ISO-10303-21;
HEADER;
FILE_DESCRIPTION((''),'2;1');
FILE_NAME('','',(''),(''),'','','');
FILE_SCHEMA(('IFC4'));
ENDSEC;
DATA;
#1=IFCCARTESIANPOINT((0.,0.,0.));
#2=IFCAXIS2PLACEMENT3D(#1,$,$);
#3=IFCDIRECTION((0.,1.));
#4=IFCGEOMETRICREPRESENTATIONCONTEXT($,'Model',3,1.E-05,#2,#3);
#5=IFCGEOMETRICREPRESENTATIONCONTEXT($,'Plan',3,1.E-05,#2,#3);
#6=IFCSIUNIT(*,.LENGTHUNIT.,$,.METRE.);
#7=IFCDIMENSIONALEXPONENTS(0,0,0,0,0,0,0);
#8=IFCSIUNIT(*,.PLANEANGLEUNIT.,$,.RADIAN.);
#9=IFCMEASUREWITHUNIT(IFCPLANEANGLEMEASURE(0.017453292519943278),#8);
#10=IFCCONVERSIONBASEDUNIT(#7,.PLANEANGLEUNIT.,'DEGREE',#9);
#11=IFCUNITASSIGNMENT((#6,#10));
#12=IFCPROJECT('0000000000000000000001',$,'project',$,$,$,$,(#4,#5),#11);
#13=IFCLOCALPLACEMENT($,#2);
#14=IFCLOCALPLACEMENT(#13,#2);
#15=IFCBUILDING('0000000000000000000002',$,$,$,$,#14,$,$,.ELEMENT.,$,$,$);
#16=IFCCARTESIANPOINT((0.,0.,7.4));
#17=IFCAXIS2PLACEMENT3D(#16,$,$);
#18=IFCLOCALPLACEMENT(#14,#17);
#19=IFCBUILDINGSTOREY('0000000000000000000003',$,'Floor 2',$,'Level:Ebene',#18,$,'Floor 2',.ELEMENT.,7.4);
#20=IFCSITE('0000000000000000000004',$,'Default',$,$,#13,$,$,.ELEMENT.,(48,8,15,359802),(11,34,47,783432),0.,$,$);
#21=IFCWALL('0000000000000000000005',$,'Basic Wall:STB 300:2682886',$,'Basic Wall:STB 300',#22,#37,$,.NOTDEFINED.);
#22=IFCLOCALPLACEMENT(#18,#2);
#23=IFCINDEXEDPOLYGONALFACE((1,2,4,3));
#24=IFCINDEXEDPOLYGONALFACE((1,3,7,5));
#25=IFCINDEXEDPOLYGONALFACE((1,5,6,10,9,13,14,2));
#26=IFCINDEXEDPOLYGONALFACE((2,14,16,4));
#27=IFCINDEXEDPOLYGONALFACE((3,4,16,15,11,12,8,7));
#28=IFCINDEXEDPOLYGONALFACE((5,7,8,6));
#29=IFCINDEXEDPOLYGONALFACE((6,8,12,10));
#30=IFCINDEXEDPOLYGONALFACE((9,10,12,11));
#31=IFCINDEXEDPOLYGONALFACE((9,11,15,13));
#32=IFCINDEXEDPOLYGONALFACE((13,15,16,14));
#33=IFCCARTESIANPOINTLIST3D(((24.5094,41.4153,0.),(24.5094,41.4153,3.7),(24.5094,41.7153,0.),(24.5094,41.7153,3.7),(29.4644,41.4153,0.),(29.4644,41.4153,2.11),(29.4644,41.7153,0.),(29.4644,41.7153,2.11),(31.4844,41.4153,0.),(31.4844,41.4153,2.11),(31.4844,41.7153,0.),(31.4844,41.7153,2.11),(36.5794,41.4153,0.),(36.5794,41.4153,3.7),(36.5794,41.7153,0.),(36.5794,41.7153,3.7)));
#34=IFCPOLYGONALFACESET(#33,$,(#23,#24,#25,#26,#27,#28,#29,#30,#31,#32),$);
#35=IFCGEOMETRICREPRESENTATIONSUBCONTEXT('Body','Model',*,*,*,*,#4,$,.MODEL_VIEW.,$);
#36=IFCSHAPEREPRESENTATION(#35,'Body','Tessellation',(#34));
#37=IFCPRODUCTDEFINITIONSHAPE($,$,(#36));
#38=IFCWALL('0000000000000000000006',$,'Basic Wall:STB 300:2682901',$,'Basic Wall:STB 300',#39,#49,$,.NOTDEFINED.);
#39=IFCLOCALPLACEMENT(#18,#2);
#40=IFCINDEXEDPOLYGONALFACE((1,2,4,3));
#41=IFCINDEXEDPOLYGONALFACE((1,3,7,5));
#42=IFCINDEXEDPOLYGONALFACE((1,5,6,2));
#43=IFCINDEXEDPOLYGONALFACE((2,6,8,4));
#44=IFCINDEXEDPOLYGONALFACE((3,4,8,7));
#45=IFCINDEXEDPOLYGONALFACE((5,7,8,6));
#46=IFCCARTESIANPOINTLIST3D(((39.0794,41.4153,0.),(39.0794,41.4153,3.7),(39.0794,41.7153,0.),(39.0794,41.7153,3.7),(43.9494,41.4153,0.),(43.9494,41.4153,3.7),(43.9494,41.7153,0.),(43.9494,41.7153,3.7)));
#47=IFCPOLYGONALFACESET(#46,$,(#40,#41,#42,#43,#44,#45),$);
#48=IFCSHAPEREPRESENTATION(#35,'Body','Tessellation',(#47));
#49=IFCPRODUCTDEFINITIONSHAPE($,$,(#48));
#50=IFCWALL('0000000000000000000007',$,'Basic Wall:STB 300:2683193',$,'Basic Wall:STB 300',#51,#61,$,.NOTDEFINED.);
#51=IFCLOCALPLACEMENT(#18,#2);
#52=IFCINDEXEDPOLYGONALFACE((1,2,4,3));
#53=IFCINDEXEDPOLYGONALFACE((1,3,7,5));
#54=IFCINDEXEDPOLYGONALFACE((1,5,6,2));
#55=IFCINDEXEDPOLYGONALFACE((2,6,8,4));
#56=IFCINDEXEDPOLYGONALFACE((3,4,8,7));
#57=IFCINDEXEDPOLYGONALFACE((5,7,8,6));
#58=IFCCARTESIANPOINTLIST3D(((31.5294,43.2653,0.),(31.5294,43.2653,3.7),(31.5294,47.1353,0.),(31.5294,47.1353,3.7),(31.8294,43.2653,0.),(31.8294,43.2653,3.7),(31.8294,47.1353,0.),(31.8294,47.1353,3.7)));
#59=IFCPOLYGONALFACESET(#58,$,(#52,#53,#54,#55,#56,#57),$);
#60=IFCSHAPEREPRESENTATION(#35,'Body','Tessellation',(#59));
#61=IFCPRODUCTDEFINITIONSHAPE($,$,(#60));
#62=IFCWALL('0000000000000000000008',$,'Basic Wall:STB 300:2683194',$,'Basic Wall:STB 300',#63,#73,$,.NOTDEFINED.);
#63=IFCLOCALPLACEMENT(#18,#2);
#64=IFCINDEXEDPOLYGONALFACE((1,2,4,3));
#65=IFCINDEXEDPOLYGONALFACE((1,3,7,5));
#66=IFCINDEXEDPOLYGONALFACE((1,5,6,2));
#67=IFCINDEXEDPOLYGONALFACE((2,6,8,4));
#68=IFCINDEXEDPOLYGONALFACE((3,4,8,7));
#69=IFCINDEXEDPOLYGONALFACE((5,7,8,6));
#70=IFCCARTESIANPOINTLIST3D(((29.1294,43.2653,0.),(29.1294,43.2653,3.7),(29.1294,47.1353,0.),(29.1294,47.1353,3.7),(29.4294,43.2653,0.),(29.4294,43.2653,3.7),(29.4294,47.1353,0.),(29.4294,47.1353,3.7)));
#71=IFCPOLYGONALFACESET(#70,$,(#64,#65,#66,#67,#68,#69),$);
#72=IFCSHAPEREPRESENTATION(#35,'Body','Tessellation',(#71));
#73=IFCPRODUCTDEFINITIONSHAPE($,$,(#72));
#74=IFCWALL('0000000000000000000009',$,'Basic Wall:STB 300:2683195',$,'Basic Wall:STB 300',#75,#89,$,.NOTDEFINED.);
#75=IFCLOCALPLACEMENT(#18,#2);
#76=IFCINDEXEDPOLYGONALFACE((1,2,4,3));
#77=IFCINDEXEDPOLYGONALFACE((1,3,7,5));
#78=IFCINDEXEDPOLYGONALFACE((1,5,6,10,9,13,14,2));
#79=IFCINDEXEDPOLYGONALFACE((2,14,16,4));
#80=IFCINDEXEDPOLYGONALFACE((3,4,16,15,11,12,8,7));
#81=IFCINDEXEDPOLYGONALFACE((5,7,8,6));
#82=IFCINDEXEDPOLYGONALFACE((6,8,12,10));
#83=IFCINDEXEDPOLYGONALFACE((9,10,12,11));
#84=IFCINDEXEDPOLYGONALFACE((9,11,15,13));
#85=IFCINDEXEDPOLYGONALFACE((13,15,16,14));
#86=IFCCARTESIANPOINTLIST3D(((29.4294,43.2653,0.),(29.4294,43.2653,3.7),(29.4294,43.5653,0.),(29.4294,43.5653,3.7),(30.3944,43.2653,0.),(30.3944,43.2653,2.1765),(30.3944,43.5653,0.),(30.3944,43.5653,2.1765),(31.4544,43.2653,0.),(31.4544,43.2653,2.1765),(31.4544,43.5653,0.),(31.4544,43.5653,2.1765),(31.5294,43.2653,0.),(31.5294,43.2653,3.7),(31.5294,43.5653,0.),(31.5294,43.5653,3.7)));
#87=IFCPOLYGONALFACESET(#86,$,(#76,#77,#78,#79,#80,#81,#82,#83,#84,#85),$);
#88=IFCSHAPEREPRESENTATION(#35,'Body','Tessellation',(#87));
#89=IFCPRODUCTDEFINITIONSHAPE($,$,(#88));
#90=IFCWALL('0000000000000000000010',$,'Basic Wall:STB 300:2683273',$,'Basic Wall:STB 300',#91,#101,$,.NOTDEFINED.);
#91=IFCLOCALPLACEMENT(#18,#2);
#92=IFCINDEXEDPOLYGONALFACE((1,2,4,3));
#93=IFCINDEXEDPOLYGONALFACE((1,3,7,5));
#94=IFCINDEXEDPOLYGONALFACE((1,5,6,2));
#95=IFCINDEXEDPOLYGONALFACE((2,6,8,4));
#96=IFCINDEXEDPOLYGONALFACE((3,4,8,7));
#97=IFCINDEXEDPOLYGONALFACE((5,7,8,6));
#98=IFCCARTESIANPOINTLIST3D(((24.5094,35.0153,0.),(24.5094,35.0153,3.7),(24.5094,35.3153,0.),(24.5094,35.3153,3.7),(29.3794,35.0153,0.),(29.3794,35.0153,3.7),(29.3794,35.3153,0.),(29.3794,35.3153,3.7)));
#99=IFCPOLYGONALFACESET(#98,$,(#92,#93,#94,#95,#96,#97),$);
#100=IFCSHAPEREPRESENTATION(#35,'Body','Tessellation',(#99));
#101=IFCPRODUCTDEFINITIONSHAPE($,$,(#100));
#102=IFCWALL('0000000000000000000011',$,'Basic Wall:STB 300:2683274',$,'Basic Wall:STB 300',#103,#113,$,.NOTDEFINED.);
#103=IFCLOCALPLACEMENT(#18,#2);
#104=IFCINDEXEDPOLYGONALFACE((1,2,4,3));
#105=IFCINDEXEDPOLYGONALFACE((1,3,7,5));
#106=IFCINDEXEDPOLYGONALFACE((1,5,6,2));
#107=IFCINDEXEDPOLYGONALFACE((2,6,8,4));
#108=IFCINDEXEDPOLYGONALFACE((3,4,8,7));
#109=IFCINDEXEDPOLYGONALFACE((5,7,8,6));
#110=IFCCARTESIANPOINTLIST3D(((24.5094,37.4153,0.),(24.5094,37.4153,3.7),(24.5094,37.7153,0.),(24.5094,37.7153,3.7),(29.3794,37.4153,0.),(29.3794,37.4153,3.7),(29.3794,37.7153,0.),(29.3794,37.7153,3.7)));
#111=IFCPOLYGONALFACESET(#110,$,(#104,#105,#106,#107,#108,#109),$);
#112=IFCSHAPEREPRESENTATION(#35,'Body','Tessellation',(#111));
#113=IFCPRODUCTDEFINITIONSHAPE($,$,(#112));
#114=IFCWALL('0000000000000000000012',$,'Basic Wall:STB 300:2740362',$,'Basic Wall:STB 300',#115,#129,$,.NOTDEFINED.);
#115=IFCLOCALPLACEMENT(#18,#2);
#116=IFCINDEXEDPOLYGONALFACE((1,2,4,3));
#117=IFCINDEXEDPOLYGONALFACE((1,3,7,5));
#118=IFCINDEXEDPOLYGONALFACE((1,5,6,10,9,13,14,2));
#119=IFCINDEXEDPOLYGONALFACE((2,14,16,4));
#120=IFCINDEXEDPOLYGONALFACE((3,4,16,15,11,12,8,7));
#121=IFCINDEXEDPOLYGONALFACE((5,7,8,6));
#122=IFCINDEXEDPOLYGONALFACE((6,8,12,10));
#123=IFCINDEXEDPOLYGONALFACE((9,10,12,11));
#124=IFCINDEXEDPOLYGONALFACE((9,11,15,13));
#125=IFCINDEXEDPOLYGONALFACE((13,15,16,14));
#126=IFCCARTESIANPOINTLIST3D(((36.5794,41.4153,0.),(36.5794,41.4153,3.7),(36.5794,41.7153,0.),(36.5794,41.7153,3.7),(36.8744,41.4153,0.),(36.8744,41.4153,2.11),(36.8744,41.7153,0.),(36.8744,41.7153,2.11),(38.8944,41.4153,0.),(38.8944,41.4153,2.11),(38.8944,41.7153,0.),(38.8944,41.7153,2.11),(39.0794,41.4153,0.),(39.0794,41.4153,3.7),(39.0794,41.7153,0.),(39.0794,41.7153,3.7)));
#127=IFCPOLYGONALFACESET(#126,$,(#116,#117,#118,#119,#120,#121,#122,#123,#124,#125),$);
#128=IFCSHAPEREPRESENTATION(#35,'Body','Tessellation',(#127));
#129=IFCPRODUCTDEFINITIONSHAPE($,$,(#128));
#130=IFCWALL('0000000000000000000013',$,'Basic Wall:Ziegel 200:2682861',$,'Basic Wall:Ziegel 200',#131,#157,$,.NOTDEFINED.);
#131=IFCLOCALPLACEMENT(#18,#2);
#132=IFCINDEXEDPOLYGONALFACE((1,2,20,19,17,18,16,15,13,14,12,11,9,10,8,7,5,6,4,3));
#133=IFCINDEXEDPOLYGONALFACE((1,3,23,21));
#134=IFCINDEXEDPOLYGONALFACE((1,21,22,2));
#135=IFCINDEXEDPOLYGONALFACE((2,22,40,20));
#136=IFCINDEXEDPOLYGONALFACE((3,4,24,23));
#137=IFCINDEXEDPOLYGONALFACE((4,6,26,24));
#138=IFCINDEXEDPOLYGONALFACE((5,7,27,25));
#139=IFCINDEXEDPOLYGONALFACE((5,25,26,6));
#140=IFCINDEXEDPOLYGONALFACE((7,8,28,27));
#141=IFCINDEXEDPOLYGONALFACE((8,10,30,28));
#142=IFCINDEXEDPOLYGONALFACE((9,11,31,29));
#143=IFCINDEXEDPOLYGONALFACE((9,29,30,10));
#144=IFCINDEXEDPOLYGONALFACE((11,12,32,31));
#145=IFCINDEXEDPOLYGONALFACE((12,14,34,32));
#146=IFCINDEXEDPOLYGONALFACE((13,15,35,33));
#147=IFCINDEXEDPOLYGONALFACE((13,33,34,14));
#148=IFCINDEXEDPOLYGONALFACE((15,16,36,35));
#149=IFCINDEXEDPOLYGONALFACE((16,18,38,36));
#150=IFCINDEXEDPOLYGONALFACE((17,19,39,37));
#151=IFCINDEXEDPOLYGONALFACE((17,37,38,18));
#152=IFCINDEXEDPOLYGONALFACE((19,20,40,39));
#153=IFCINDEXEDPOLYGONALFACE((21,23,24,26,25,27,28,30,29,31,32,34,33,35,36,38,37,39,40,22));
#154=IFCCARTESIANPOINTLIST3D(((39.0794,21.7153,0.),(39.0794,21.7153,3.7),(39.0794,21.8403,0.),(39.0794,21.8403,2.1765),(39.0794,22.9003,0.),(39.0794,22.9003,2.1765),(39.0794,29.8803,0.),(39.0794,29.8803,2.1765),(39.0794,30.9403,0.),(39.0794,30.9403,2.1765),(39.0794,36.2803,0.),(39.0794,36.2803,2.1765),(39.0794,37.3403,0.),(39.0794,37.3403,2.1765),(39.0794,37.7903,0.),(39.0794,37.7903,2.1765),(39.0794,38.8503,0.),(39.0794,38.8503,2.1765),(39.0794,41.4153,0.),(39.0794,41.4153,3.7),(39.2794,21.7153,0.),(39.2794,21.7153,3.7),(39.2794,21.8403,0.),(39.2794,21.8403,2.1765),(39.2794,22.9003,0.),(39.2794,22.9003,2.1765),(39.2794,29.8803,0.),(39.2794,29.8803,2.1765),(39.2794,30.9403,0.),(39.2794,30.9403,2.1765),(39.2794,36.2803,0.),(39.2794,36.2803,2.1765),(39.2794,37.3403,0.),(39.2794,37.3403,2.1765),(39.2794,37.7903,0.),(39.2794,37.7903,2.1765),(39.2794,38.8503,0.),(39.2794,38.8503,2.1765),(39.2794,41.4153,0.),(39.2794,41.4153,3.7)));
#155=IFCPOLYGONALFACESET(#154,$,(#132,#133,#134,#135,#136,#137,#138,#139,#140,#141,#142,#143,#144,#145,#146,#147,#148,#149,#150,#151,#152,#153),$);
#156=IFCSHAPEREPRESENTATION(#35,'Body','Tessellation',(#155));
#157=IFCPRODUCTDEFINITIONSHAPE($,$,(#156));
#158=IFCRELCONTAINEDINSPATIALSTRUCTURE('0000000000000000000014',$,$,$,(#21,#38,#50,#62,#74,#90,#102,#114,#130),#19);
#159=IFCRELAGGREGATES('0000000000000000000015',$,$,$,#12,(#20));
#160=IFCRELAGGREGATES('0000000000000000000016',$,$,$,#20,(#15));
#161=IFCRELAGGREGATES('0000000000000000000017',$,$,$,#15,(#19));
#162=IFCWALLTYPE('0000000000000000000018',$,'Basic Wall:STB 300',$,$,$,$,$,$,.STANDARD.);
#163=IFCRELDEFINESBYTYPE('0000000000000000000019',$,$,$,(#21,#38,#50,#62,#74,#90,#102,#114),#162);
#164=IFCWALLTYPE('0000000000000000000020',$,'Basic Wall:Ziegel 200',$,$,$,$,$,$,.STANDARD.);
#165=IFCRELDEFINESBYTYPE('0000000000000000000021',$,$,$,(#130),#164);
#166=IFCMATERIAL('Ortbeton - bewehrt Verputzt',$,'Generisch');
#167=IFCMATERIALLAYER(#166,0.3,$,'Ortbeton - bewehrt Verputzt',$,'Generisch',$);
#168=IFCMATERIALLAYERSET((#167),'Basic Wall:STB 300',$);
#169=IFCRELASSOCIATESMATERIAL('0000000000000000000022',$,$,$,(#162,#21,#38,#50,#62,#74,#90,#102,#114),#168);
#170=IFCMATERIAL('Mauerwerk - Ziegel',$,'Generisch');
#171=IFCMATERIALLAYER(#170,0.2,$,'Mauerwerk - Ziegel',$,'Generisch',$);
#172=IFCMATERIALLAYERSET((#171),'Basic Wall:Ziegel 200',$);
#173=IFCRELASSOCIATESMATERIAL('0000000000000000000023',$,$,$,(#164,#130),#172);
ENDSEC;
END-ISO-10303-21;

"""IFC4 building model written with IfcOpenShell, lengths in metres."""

from ifc_helpers import new_model, entity, si_unit, converted_unit, direction, frame, frame_2d, origin, place, context, subcontext, project, spatial, rectangle, extrude, material, layer, layer_set, layer_usage, type_object, element, save


model = new_model("IFC4")

# Units and contexts
model_context = context("Model", 3, precision=1e-05, world=origin(), true_north=direction((0.0, 1.0)))
plan_context = context("Plan", 3, precision=1e-05, world=origin(), true_north=direction((0.0, 1.0)))
body_context = subcontext(model_context, "Body", "Model", "MODEL_VIEW")
ifc_project = project(units=[si_unit("LENGTHUNIT", "METRE"), converted_unit("PLANEANGLEUNIT", "DEGREE", entity("IfcPlaneAngleMeasure", 0.017453292519943278), si_unit("PLANEANGLEUNIT", "RADIAN"), dimensions=[0, 0, 0, 0, 0, 0, 0])], contexts=[model_context, plan_context])

# Site, building, storey
site_placement = place(None, origin())
site = spatial("IfcSite", under=ifc_project, at=site_placement, Name="Default", CompositionType="ELEMENT", RefLatitude=(48, 8, 15, 359802), RefLongitude=(11, 34, 47, 783432), RefElevation=0.0)
building_placement = place(site_placement, origin())
building = spatial("IfcBuilding", under=site, at=building_placement, CompositionType="ELEMENT")
storey_placement = place(building_placement, frame((0.0, 0.0, 7.4)))
storey = spatial("IfcBuildingStorey", under=building, at=storey_placement, Name="Floor 2", ObjectType="Level:Ebene", LongName="Floor 2", CompositionType="ELEMENT", Elevation=7.4)

# Wall, opening
ifc_material_1 = material(Name="Ortbeton - bewehrt Verputzt", Category="Generisch")
ifc_layer_1 = layer(ifc_material_1, 0.3, Name="Ortbeton - bewehrt Verputzt", Category="Generisch")
ifc_layer_set_1 = layer_set([ifc_layer_1], Name="Basic Wall:STB 300")
ifc_layer_usage_1 = layer_usage(ifc_layer_set_1, "AXIS2", "NEGATIVE", 0.15)
wall_type_1 = type_object("IfcWallType", Name="Basic Wall:STB 300", PredefinedType="STANDARD", material=ifc_layer_set_1)
wall_1_placement = place(storey_placement, frame((24.5094, 41.5653, 0.0)))
wall_1 = element("IfcWall", 1, at=wall_1_placement, inside=storey, type_object=wall_type_1, material=ifc_layer_usage_1, Name="Basic Wall:STB 300:2682886", ObjectType="Basic Wall:STB 300", PredefinedType="NOTDEFINED", context=body_context, shape_type="SweptSolid", body=[
    extrude(rectangle(XDim=12.07, YDim=0.3, at=frame_2d((6.035, 0.0), x_axis=(-1.0, 0.0))), origin(), (0.0, 0.0, 1.0), 3.7),
])
opening_1_placement = place(wall_1_placement, frame((6.975, 0.15, 0.0)))
element("IfcOpeningElement", 2, at=opening_1_placement, cuts=wall_1, PredefinedType="OPENING", context=body_context, shape_type="SweptSolid", body=[
    extrude(rectangle(XDim=2.11, YDim=2.02, at=frame_2d((1.055, 1.01), x_axis=(1.0, 0.0))), frame((0.0, 0.0, 0.0), z_axis=(0.0, -1.0, 0.0), x_axis=(0.0, 0.0, 1.0)), (0.0, 0.0, 1.0), 0.3),
])

# Walls
wall_2_placement = place(storey_placement, frame((39.0794, 41.5653, 0.0)))
element("IfcWall", 3, at=wall_2_placement, inside=storey, type_object=wall_type_1, material=ifc_layer_usage_1, Name="Basic Wall:STB 300:2682901", ObjectType="Basic Wall:STB 300", PredefinedType="NOTDEFINED", context=body_context, shape_type="SweptSolid", body=[
    extrude(rectangle(XDim=4.87, YDim=0.3, at=frame_2d((2.435, 0.0), x_axis=(-1.0, 0.0))), origin(), (0.0, 0.0, 1.0), 3.7),
])
wall_3_placement = place(storey_placement, frame((31.6794, 47.1353, 0.0), z_axis=(0.0, 0.0, 1.0), x_axis=(0.0, -1.0, 0.0)))
element("IfcWall", 4, at=wall_3_placement, inside=storey, type_object=wall_type_1, material=ifc_layer_usage_1, Name="Basic Wall:STB 300:2683193", ObjectType="Basic Wall:STB 300", PredefinedType="NOTDEFINED", context=body_context, shape_type="SweptSolid", body=[
    extrude(rectangle(XDim=3.87, YDim=0.3, at=frame_2d((1.935, 0.0), x_axis=(-1.0, 0.0))), origin(), (0.0, 0.0, 1.0), 3.7),
])
wall_4_placement = place(storey_placement, frame((29.2794, 43.2653, 0.0), z_axis=(0.0, 0.0, 1.0), x_axis=(0.0, 1.0, 0.0)))
element("IfcWall", 5, at=wall_4_placement, inside=storey, type_object=wall_type_1, material=ifc_layer_usage_1, Name="Basic Wall:STB 300:2683194", ObjectType="Basic Wall:STB 300", PredefinedType="NOTDEFINED", context=body_context, shape_type="SweptSolid", body=[
    extrude(rectangle(XDim=3.87, YDim=0.3, at=frame_2d((1.935, 0.0), x_axis=(-1.0, 0.0))), origin(), (0.0, 0.0, 1.0), 3.7),
])

# Wall, opening
wall_5_placement = place(storey_placement, frame((29.4294, 43.4153, 0.0)))
wall_5 = element("IfcWall", 6, at=wall_5_placement, inside=storey, type_object=wall_type_1, material=ifc_layer_usage_1, Name="Basic Wall:STB 300:2683195", ObjectType="Basic Wall:STB 300", PredefinedType="NOTDEFINED", context=body_context, shape_type="SweptSolid", body=[
    extrude(rectangle(XDim=2.1, YDim=0.3, at=frame_2d((1.05, 0.0), x_axis=(1.0, 0.0))), origin(), (0.0, 0.0, 1.0), 3.7),
])
opening_2_placement = place(wall_5_placement, frame((0.965, -0.15, 0.0)))
element("IfcOpeningElement", 7, at=opening_2_placement, cuts=wall_5, PredefinedType="OPENING", context=body_context, shape_type="SweptSolid", body=[
    extrude(rectangle(XDim=2.1765, YDim=1.06, at=frame_2d((1.0882, 0.53), x_axis=(1.0, 0.0))), frame((0.0, 0.0, 0.0), z_axis=(0.0, 1.0, 0.0), x_axis=(0.0, 0.0, 1.0)), (0.0, 0.0, 1.0), 0.3),
])

# Walls
wall_6_placement = place(storey_placement, frame((29.3794, 35.1653, 0.0), z_axis=(0.0, 0.0, 1.0), x_axis=(-1.0, 0.0, 0.0)))
element("IfcWall", 8, at=wall_6_placement, inside=storey, type_object=wall_type_1, material=ifc_layer_usage_1, Name="Basic Wall:STB 300:2683273", ObjectType="Basic Wall:STB 300", PredefinedType="NOTDEFINED", context=body_context, shape_type="SweptSolid", body=[
    extrude(rectangle(XDim=4.87, YDim=0.3, at=frame_2d((2.435, 0.0), x_axis=(-1.0, 0.0))), origin(), (0.0, 0.0, 1.0), 3.7),
])
wall_7_placement = place(storey_placement, frame((29.3794, 37.5653, 0.0), z_axis=(0.0, 0.0, 1.0), x_axis=(-1.0, 0.0, 0.0)))
element("IfcWall", 9, at=wall_7_placement, inside=storey, type_object=wall_type_1, material=ifc_layer_usage_1, Name="Basic Wall:STB 300:2683274", ObjectType="Basic Wall:STB 300", PredefinedType="NOTDEFINED", context=body_context, shape_type="SweptSolid", body=[
    extrude(rectangle(XDim=4.87, YDim=0.3, at=frame_2d((2.435, 0.0), x_axis=(-1.0, 0.0))), origin(), (0.0, 0.0, 1.0), 3.7),
])

# Wall, opening
wall_8_placement = place(storey_placement, frame((36.5794, 41.5653, 0.0)))
wall_8 = element("IfcWall", 10, at=wall_8_placement, inside=storey, type_object=wall_type_1, material=ifc_layer_usage_1, Name="Basic Wall:STB 300:2740362", ObjectType="Basic Wall:STB 300", PredefinedType="NOTDEFINED", context=body_context, shape_type="SweptSolid", body=[
    extrude(rectangle(XDim=2.5, YDim=0.3, at=frame_2d((1.25, 0.0), x_axis=(-1.0, 0.0))), origin(), (0.0, 0.0, 1.0), 3.7),
])
opening_3_placement = place(wall_8_placement, frame((2.315, 0.15, 0.0)))
element("IfcOpeningElement", 11, at=opening_3_placement, cuts=wall_8, PredefinedType="OPENING", context=body_context, shape_type="SweptSolid", body=[
    extrude(rectangle(XDim=2.11, YDim=2.02, at=frame_2d((1.055, 1.01), x_axis=(1.0, 0.0))), frame((0.0, 0.0, 0.0), z_axis=(0.0, -1.0, 0.0), x_axis=(0.0, 0.0, 1.0)), (0.0, 0.0, 1.0), 0.3),
])

# Wall, openings
ifc_material_2 = material(Name="Mauerwerk - Ziegel", Category="Generisch")
ifc_layer_2 = layer(ifc_material_2, 0.2, Name="Mauerwerk - Ziegel", Category="Generisch")
ifc_layer_set_2 = layer_set([ifc_layer_2], Name="Basic Wall:Ziegel 200")
ifc_layer_usage_2 = layer_usage(ifc_layer_set_2, "AXIS2", "NEGATIVE", 0.1)
wall_type_2 = type_object("IfcWallType", Name="Basic Wall:Ziegel 200", PredefinedType="STANDARD", material=ifc_layer_set_2)
wall_9_placement = place(storey_placement, frame((39.1794, 41.4153, 0.0), z_axis=(0.0, 0.0, 1.0), x_axis=(0.0, -1.0, 0.0)))
wall_9 = element("IfcWall", 12, at=wall_9_placement, inside=storey, type_object=wall_type_2, material=ifc_layer_usage_2, Name="Basic Wall:Ziegel 200:2682861", ObjectType="Basic Wall:Ziegel 200", PredefinedType="NOTDEFINED", context=body_context, shape_type="SweptSolid", body=[
    extrude(rectangle(XDim=19.7, YDim=0.2, at=frame_2d((9.85, 0.0), x_axis=(-1.0, 0.0))), origin(), (0.0, 0.0, 1.0), 3.7),
])
opening_4_placement = place(wall_9_placement, frame((11.535, 0.1, 0.0)))
element("IfcOpeningElement", 13, at=opening_4_placement, cuts=wall_9, PredefinedType="OPENING", context=body_context, shape_type="SweptSolid", body=[
    extrude(rectangle(XDim=2.1765, YDim=1.06, at=frame_2d((1.0882, 0.53), x_axis=(1.0, 0.0))), frame((0.0, 0.0, 0.0), z_axis=(0.0, -1.0, 0.0), x_axis=(0.0, 0.0, 1.0)), (0.0, 0.0, 1.0), 0.2),
])
opening_5_placement = place(wall_9_placement, frame((5.135, 0.1, 0.0)))
element("IfcOpeningElement", 14, at=opening_5_placement, cuts=wall_9, PredefinedType="OPENING", context=body_context, shape_type="SweptSolid", body=[
    extrude(rectangle(XDim=2.1765, YDim=1.06, at=frame_2d((1.0882, 0.53), x_axis=(1.0, 0.0))), frame((0.0, 0.0, 0.0), z_axis=(0.0, -1.0, 0.0), x_axis=(0.0, 0.0, 1.0)), (0.0, 0.0, 1.0), 0.2),
])
opening_6_placement = place(wall_9_placement, frame((3.625, 0.1, 0.0)))
element("IfcOpeningElement", 15, at=opening_6_placement, cuts=wall_9, PredefinedType="OPENING", context=body_context, shape_type="SweptSolid", body=[
    extrude(rectangle(XDim=2.1765, YDim=1.06, at=frame_2d((1.0882, 0.53), x_axis=(1.0, 0.0))), frame((0.0, 0.0, 0.0), z_axis=(0.0, -1.0, 0.0), x_axis=(0.0, 0.0, 1.0)), (0.0, 0.0, 1.0), 0.2),
])
opening_7_placement = place(wall_9_placement, frame((19.575, 0.1, 0.0)))
element("IfcOpeningElement", 16, at=opening_7_placement, cuts=wall_9, PredefinedType="OPENING", context=body_context, shape_type="SweptSolid", body=[
    extrude(rectangle(XDim=2.1765, YDim=1.06, at=frame_2d((1.0882, 0.53), x_axis=(1.0, 0.0))), frame((0.0, 0.0, 0.0), z_axis=(0.0, -1.0, 0.0), x_axis=(0.0, 0.0, 1.0)), (0.0, 0.0, 1.0), 0.2),
])

save(model, "model.ifc")
